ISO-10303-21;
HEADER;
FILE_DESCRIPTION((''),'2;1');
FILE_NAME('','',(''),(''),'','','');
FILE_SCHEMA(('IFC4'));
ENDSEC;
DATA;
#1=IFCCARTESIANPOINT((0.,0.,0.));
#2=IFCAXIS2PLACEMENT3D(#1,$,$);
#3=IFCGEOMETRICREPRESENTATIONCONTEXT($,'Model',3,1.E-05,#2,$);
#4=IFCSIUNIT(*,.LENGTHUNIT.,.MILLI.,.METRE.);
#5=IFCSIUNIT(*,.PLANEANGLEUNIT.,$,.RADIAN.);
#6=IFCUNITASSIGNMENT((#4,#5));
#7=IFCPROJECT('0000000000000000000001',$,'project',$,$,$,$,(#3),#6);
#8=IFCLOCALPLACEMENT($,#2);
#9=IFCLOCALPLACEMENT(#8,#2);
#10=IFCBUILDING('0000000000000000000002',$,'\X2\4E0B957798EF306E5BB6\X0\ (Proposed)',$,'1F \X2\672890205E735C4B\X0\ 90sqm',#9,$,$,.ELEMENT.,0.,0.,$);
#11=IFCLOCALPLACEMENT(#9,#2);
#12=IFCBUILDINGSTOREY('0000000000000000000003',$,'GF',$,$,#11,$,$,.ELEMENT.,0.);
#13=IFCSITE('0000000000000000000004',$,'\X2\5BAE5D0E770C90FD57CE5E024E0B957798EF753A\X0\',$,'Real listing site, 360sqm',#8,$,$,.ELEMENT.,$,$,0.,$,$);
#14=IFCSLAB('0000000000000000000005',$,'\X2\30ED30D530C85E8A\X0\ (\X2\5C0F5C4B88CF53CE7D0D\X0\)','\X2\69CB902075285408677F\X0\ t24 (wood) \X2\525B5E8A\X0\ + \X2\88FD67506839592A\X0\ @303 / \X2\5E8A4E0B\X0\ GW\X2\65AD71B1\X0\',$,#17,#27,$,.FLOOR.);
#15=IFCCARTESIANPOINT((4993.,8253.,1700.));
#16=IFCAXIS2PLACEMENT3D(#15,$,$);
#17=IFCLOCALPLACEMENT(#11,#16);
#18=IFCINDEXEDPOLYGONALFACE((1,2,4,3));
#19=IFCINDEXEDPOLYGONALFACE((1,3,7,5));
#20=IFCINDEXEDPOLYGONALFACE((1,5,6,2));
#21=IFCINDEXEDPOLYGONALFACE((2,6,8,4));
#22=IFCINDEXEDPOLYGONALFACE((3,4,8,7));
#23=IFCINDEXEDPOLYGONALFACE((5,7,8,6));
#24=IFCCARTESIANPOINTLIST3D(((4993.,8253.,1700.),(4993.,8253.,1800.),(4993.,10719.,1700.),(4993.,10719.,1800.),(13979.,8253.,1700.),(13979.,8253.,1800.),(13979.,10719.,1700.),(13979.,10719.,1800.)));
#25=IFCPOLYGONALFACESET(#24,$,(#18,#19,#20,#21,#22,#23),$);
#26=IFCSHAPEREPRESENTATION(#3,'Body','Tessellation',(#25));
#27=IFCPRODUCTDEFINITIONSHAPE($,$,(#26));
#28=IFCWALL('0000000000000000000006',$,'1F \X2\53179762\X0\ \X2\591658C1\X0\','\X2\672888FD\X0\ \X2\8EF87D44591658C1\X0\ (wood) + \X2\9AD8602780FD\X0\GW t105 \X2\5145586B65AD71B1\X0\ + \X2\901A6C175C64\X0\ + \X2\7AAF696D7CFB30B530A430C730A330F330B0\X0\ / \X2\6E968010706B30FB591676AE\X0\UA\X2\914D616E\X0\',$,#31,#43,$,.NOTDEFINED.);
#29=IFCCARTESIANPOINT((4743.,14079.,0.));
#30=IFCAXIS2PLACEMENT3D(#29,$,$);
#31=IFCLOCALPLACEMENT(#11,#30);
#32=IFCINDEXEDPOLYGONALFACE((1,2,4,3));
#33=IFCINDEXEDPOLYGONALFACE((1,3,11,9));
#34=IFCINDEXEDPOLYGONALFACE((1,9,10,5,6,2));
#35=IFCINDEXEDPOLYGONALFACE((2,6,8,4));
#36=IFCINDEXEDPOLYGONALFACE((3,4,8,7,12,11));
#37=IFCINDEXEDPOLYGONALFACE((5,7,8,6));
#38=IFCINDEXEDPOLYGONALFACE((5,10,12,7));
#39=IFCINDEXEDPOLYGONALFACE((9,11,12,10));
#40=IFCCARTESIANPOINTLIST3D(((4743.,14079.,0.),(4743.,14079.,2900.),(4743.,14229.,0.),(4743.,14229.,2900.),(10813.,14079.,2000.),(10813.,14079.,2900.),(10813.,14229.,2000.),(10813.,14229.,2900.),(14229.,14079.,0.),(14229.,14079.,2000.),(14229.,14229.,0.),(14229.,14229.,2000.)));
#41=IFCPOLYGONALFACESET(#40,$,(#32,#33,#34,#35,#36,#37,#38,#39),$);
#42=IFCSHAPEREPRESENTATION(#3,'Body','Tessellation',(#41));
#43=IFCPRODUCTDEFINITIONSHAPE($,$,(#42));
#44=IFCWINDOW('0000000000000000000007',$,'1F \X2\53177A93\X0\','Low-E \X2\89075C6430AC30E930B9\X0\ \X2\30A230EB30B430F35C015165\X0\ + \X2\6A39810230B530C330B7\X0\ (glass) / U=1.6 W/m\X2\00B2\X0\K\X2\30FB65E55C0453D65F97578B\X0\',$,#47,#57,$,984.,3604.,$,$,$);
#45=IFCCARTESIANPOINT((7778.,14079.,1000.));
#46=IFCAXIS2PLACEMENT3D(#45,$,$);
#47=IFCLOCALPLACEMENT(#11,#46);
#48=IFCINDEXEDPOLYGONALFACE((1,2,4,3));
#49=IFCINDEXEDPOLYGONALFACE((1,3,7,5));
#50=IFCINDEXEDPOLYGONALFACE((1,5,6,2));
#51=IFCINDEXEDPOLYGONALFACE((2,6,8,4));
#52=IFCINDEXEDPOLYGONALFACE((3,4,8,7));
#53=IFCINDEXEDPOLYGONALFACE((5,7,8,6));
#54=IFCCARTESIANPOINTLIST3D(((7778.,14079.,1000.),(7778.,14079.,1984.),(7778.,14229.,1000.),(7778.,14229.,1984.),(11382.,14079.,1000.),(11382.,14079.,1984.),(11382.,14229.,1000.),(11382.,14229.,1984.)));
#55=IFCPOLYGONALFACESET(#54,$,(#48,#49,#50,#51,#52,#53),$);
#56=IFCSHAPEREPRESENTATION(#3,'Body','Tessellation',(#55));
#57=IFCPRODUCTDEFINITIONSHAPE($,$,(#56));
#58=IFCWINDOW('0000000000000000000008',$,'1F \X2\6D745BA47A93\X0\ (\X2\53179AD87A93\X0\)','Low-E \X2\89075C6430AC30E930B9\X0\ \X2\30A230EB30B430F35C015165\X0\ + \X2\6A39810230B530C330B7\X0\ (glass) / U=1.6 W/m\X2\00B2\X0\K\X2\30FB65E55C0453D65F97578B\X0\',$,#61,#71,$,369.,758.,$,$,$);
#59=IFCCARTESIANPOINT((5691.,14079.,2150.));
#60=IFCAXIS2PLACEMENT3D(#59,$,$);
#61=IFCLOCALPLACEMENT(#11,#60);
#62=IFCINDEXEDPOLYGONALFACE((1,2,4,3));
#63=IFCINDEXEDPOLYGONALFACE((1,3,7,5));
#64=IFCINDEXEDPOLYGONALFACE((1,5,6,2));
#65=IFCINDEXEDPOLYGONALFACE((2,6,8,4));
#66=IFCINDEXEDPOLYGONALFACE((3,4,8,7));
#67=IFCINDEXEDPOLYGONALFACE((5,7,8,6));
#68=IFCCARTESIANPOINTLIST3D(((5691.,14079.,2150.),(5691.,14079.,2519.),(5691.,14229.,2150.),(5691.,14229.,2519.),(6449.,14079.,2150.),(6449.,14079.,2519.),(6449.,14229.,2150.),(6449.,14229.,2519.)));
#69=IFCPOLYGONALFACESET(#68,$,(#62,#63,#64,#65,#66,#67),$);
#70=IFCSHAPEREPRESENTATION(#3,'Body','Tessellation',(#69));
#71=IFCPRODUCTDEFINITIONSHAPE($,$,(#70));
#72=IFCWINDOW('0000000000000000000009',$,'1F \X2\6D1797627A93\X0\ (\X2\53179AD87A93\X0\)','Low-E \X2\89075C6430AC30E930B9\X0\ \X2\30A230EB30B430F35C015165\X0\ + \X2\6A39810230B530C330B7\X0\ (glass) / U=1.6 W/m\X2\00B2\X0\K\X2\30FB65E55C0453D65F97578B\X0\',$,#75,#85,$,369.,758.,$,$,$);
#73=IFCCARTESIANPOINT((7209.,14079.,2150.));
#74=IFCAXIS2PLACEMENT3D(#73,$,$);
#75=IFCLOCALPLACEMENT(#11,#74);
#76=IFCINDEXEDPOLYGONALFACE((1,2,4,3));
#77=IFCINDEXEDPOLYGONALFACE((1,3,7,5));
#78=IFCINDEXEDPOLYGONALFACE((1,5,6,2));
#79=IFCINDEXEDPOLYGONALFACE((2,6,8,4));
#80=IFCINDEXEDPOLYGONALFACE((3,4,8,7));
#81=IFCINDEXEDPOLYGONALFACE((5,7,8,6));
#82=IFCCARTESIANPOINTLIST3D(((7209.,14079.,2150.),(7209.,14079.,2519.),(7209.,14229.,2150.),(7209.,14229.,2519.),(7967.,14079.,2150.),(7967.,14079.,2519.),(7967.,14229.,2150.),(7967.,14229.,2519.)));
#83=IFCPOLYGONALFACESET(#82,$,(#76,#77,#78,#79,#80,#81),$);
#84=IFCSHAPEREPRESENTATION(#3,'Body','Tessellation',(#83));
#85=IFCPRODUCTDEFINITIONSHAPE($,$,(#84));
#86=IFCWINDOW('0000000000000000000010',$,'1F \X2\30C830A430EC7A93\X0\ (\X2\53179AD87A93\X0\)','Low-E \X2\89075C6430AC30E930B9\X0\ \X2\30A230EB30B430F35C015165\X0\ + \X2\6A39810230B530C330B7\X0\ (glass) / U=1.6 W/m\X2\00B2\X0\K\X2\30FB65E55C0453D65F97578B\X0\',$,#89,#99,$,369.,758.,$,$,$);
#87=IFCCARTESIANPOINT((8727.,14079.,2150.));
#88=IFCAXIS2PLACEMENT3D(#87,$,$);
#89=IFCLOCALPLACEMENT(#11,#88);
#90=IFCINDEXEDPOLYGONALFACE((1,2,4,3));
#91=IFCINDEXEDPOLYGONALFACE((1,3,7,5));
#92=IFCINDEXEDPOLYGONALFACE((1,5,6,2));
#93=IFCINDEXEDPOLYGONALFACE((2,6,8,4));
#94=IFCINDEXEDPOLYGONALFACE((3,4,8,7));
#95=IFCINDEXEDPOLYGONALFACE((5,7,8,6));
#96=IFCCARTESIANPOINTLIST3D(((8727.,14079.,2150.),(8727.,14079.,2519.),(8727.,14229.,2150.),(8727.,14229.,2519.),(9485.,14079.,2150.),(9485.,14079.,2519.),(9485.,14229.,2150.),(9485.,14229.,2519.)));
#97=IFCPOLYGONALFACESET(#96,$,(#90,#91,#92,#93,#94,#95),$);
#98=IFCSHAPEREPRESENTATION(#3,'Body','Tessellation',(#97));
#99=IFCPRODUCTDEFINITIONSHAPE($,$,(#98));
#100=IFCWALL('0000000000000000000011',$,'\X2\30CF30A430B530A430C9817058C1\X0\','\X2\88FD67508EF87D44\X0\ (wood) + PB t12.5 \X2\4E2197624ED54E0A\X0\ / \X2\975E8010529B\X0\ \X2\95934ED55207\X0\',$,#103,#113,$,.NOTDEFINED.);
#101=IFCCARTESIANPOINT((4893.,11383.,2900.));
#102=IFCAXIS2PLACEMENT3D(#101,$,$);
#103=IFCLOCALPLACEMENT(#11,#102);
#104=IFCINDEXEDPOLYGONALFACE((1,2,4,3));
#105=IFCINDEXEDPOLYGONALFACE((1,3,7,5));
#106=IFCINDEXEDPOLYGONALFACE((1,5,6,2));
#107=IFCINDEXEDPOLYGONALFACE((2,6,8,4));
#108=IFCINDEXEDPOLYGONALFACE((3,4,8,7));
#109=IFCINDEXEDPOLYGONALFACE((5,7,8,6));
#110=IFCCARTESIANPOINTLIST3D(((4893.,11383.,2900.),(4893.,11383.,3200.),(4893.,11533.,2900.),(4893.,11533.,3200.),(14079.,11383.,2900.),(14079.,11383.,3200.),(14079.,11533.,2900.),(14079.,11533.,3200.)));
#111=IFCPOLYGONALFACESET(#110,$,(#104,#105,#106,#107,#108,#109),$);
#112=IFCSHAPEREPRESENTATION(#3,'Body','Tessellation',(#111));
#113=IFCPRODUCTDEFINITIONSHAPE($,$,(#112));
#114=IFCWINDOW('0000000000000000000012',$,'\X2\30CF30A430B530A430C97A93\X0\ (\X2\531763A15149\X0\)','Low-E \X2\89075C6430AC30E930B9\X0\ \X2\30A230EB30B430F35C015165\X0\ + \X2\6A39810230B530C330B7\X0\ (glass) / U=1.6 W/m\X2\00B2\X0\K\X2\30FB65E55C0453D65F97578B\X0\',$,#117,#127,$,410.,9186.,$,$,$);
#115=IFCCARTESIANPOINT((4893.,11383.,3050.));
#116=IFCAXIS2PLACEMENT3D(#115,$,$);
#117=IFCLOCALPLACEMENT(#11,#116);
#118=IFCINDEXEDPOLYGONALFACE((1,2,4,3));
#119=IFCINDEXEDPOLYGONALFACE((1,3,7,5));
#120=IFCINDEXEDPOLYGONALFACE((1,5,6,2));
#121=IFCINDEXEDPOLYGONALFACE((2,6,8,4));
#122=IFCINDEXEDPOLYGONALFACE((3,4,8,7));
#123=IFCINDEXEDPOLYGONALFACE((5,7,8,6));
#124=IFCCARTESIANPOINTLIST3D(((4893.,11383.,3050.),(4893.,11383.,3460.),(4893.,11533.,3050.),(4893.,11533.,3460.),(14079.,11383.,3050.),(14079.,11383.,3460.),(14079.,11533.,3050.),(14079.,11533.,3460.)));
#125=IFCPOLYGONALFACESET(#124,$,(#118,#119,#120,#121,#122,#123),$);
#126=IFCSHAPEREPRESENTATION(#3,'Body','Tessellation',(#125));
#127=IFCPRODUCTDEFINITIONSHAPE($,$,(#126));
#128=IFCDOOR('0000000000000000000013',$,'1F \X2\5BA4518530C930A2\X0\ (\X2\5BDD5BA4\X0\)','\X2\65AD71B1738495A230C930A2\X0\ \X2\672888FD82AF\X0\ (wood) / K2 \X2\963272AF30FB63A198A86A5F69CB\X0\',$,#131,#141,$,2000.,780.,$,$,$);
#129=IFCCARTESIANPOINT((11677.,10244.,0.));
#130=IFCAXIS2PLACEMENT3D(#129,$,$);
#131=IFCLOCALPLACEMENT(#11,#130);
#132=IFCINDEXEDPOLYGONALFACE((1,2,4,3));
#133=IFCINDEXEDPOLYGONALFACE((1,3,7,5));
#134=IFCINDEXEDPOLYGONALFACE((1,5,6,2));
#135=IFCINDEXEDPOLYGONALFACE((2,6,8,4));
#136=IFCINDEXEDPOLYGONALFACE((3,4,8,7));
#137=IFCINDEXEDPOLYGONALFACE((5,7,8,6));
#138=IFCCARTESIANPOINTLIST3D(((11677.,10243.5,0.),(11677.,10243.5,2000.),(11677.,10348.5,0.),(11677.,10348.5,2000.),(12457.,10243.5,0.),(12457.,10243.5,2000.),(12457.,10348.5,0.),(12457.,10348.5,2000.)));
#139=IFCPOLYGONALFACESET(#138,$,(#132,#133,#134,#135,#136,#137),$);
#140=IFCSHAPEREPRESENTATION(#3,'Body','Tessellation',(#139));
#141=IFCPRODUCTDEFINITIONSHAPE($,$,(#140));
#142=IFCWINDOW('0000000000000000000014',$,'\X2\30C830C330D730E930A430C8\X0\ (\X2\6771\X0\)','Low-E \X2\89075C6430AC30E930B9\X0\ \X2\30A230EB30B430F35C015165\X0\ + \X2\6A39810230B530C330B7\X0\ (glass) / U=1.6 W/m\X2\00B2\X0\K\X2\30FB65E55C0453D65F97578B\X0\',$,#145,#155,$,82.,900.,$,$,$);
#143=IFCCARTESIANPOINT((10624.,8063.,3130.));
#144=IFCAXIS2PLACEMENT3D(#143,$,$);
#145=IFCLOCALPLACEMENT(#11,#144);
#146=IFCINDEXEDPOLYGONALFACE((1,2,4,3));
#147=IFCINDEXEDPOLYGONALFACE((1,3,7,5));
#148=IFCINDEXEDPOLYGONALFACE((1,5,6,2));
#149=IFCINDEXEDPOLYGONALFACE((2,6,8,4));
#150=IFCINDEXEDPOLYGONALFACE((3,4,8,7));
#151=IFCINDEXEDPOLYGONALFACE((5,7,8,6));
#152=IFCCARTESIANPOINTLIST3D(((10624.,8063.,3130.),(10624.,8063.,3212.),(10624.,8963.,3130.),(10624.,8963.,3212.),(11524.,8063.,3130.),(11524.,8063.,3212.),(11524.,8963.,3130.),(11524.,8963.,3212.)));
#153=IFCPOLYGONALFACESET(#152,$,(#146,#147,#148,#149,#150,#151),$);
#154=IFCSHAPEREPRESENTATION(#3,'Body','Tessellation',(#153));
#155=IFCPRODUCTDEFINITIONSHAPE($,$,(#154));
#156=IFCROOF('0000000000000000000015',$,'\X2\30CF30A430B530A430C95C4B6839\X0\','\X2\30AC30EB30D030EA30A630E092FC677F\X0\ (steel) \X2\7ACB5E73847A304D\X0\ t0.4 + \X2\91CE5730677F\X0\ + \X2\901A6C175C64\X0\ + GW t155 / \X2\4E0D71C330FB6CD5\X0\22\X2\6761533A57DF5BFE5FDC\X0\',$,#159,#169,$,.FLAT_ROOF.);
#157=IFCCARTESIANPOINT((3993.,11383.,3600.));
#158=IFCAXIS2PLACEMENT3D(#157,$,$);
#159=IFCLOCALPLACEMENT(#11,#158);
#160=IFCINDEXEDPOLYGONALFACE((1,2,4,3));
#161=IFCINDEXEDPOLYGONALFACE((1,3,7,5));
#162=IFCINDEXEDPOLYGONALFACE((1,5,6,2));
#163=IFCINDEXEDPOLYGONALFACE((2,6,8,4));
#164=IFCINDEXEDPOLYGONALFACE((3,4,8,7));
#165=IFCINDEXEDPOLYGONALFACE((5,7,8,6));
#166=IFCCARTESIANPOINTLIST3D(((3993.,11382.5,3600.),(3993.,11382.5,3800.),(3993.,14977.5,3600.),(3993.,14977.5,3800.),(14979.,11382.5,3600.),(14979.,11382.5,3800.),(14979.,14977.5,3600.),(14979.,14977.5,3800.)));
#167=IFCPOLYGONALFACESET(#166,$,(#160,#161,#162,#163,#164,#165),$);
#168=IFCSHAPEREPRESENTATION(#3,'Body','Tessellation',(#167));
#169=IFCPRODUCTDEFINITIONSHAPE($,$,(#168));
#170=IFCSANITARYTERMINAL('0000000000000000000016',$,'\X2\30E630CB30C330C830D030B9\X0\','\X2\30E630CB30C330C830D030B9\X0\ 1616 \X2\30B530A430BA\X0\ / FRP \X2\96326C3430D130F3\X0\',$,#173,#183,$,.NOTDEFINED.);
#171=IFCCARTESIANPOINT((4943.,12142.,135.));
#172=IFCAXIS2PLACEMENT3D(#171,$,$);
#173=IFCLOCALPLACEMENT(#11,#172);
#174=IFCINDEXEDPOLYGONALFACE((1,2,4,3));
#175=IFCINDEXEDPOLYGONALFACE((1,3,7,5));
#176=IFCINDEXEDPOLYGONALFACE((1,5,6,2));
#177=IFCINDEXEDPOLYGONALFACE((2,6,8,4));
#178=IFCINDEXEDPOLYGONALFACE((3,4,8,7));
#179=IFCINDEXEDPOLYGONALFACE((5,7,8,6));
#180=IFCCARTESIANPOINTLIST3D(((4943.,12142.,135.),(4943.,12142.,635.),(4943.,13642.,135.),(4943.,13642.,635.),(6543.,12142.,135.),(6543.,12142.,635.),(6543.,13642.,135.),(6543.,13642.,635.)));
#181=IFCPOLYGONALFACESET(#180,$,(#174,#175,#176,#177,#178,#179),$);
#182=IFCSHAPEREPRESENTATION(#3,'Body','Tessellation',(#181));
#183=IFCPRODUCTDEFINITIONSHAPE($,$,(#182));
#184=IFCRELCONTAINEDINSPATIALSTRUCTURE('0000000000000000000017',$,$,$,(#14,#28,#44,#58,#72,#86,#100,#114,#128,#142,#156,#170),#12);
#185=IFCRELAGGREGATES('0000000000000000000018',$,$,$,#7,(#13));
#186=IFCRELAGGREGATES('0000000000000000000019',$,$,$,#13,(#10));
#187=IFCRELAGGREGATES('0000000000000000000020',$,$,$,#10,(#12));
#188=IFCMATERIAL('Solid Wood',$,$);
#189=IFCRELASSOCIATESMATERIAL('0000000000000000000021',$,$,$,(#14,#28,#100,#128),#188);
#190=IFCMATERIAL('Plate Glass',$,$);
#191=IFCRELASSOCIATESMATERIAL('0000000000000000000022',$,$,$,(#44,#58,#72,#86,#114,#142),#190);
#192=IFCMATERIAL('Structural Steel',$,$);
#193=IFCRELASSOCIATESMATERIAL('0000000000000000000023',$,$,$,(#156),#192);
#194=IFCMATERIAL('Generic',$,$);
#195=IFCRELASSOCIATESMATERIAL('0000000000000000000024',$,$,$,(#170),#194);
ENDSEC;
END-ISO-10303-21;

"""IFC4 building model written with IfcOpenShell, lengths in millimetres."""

from ifc_helpers import new_model, si_unit, frame, frame_2d, origin, place, context, project, spatial, rectangle, extrude, material, element, fill, save


model = new_model("IFC4")

# Units and contexts
model_context = context("Model", 3, precision=1e-05, world=origin())
ifc_project = project(units=[si_unit("LENGTHUNIT", "METRE", prefix="MILLI"), si_unit("PLANEANGLEUNIT", "RADIAN")], contexts=[model_context])

# Site, building, storey
site_placement = place(None, origin())
site = spatial("IfcSite", under=ifc_project, at=site_placement, Name="宮崎県都城市下長飯町", ObjectType="Real listing site, 360sqm", CompositionType="ELEMENT", RefElevation=0.0)
building_placement = place(site_placement, origin())
building = spatial("IfcBuilding", under=site, at=building_placement, Name="下長飯の家 (Proposed)", ObjectType="1F 木造平屋 90sqm", CompositionType="ELEMENT", ElevationOfRefHeight=0.0, ElevationOfTerrain=0.0)
storey_placement = place(building_placement, origin())
storey = spatial("IfcBuildingStorey", under=building, at=storey_placement, Name="GF", CompositionType="ELEMENT", Elevation=0.0)

# Slab
ifc_material_1 = material(Name="Solid Wood")
slab_placement = place(storey_placement, frame((4993.0, 8253.0, 1700.0)))
element("IfcSlab", 1, at=slab_placement, inside=storey, material=ifc_material_1, Name="ロフト床 (小屋裏収納)", Description="構造用合板 t24 (wood) 剛床 + 製材根太 @303 / 床下 GW断熱", PredefinedType="FLOOR", context=model_context, shape_type="SweptSolid", body=[
    extrude(rectangle(XDim=8986.0, YDim=2466.0, at=frame_2d((4493.0, 1233.0))), frame((4993.0, 8253.0, 1700.0)), (0.0, 0.0, 1.0), 100.0),
])

# Wall, openings, windows
wall_1_placement = place(storey_placement, frame((4743.0, 14079.0, 0.0)))
wall_1 = element("IfcWall", 2, at=wall_1_placement, inside=storey, material=ifc_material_1, Name="1F 北面 外壁", Description="木製 軸組外壁 (wood) + 高性能GW t105 充填断熱 + 通気層 + 窯業系サイディング / 準耐火・外皮UA配慮", PredefinedType="NOTDEFINED", context=model_context, shape_type="SweptSolid", body=[
    extrude(rectangle(XDim=9486.0, YDim=150.0, at=frame_2d((4743.0, 75.0))), frame((4743.0, 14079.0, 0.0)), (0.0, 0.0, 1.0), 2900.0),
])
opening_1_placement = place(storey_placement, frame((7778.0, 14079.0, 1000.0)))
opening_1 = element("IfcOpeningElement", 3, at=opening_1_placement, cuts=wall_1, PredefinedType="NOTDEFINED", context=model_context, shape_type="SweptSolid", body=[
    extrude(rectangle(XDim=3604.0, YDim=150.0, at=frame_2d((1802.0, 75.0))), frame((7778.0, 14079.0, 1000.0)), (0.0, 0.0, 1.0), 984.0),
])
opening_2_placement = place(storey_placement, frame((5691.0, 14079.0, 2150.0)))
opening_2 = element("IfcOpeningElement", 4, at=opening_2_placement, cuts=wall_1, PredefinedType="NOTDEFINED", context=model_context, shape_type="SweptSolid", body=[
    extrude(rectangle(XDim=758.0, YDim=150.0, at=frame_2d((379.0, 75.0))), frame((5691.0, 14079.0, 2150.0)), (0.0, 0.0, 1.0), 369.0),
])
opening_3_placement = place(storey_placement, frame((7209.0, 14079.0, 2150.0)))
opening_3 = element("IfcOpeningElement", 5, at=opening_3_placement, cuts=wall_1, PredefinedType="NOTDEFINED", context=model_context, shape_type="SweptSolid", body=[
    extrude(rectangle(XDim=758.0, YDim=150.0, at=frame_2d((379.0, 75.0))), frame((7209.0, 14079.0, 2150.0)), (0.0, 0.0, 1.0), 369.0),
])
opening_4_placement = place(storey_placement, frame((8727.0, 14079.0, 2150.0)))
opening_4 = element("IfcOpeningElement", 6, at=opening_4_placement, cuts=wall_1, PredefinedType="NOTDEFINED", context=model_context, shape_type="SweptSolid", body=[
    extrude(rectangle(XDim=758.0, YDim=150.0, at=frame_2d((379.0, 75.0))), frame((8727.0, 14079.0, 2150.0)), (0.0, 0.0, 1.0), 369.0),
])
ifc_material_2 = material(Name="Plate Glass")
window_1_placement = place(storey_placement, frame((7778.0, 14079.0, 1000.0)))
window_1 = element("IfcWindow", 7, at=window_1_placement, inside=storey, material=ifc_material_2, Name="1F 北窓", Description="Low-E 複層ガラス アルゴン封入 + 樹脂サッシ (glass) / U=1.6 W/m²K・日射取得型", OverallHeight=984.0, OverallWidth=3604.0, context=model_context, shape_type="SweptSolid", body=[
    extrude(rectangle(XDim=3604.0, YDim=150.0, at=frame_2d((1802.0, 75.0))), frame((7778.0, 14079.0, 1000.0)), (0.0, 0.0, 1.0), 984.0),
])
fill(opening_1, window_1)
window_2_placement = place(storey_placement, frame((5691.0, 14079.0, 2150.0)))
window_2 = element("IfcWindow", 8, at=window_2_placement, inside=storey, material=ifc_material_2, Name="1F 浴室窓 (北高窓)", Description="Low-E 複層ガラス アルゴン封入 + 樹脂サッシ (glass) / U=1.6 W/m²K・日射取得型", OverallHeight=369.0, OverallWidth=758.0, context=model_context, shape_type="SweptSolid", body=[
    extrude(rectangle(XDim=758.0, YDim=150.0, at=frame_2d((379.0, 75.0))), frame((5691.0, 14079.0, 2150.0)), (0.0, 0.0, 1.0), 369.0),
])
fill(opening_2, window_2)
window_3_placement = place(storey_placement, frame((7209.0, 14079.0, 2150.0)))
window_3 = element("IfcWindow", 9, at=window_3_placement, inside=storey, material=ifc_material_2, Name="1F 洗面窓 (北高窓)", Description="Low-E 複層ガラス アルゴン封入 + 樹脂サッシ (glass) / U=1.6 W/m²K・日射取得型", OverallHeight=369.0, OverallWidth=758.0, context=model_context, shape_type="SweptSolid", body=[
    extrude(rectangle(XDim=758.0, YDim=150.0, at=frame_2d((379.0, 75.0))), frame((7209.0, 14079.0, 2150.0)), (0.0, 0.0, 1.0), 369.0),
])
fill(opening_3, window_3)
window_4_placement = place(storey_placement, frame((8727.0, 14079.0, 2150.0)))
window_4 = element("IfcWindow", 10, at=window_4_placement, inside=storey, material=ifc_material_2, Name="1F トイレ窓 (北高窓)", Description="Low-E 複層ガラス アルゴン封入 + 樹脂サッシ (glass) / U=1.6 W/m²K・日射取得型", OverallHeight=369.0, OverallWidth=758.0, context=model_context, shape_type="SweptSolid", body=[
    extrude(rectangle(XDim=758.0, YDim=150.0, at=frame_2d((379.0, 75.0))), frame((8727.0, 14079.0, 2150.0)), (0.0, 0.0, 1.0), 369.0),
])
fill(opening_4, window_4)

# Wall, opening, window
wall_2_placement = place(storey_placement, frame((4893.0, 11383.0, 2900.0)))
wall_2 = element("IfcWall", 11, at=wall_2_placement, inside=storey, material=ifc_material_1, Name="ハイサイド腰壁", Description="製材軸組 (wood) + PB t12.5 両面仕上 / 非耐力 間仕切", PredefinedType="NOTDEFINED", context=model_context, shape_type="SweptSolid", body=[
    extrude(rectangle(XDim=9186.0, YDim=150.0, at=frame_2d((4593.0, 75.0))), frame((4893.0, 11383.0, 2900.0)), (0.0, 0.0, 1.0), 700.0),
])
opening_5_placement = place(storey_placement, frame((4893.0, 11383.0, 3050.0)))
opening_5 = element("IfcOpeningElement", 12, at=opening_5_placement, cuts=wall_2, PredefinedType="NOTDEFINED", context=model_context, shape_type="SweptSolid", body=[
    extrude(rectangle(XDim=9186.0, YDim=150.0, at=frame_2d((4593.0, 75.0))), frame((4893.0, 11383.0, 3050.0)), (0.0, 0.0, 1.0), 410.0),
])
window_5_placement = place(storey_placement, frame((4893.0, 11383.0, 3050.0)))
window_5 = element("IfcWindow", 13, at=window_5_placement, inside=storey, material=ifc_material_2, Name="ハイサイド窓 (北採光)", Description="Low-E 複層ガラス アルゴン封入 + 樹脂サッシ (glass) / U=1.6 W/m²K・日射取得型", OverallHeight=410.0, OverallWidth=9186.0, context=model_context, shape_type="SweptSolid", body=[
    extrude(rectangle(XDim=9186.0, YDim=150.0, at=frame_2d((4593.0, 75.0))), frame((4893.0, 11383.0, 3050.0)), (0.0, 0.0, 1.0), 410.0),
])
fill(opening_5, window_5)

# Door
door_1_placement = place(storey_placement, frame((11677.0, 10244.0, 0.0)))
element("IfcDoor", 14, at=door_1_placement, inside=storey, material=ifc_material_1, Name="1F 室内ドア (寝室)", Description="断熱玄関ドア 木製芯 (wood) / K2 防犯・採風機構", OverallHeight=2000.0, OverallWidth=780.0, context=model_context, shape_type="SweptSolid", body=[
    extrude(rectangle(XDim=780.0, YDim=105.0, at=frame_2d((390.0, 52.0))), frame((11677.0, 10244.0, 0.0)), (0.0, 0.0, 1.0), 2000.0),
])

# Window
window_6_placement = place(storey_placement, frame((10624.0, 8063.0, 3130.0)))
element("IfcWindow", 15, at=window_6_placement, inside=storey, material=ifc_material_2, Name="トップライト (東)", Description="Low-E 複層ガラス アルゴン封入 + 樹脂サッシ (glass) / U=1.6 W/m²K・日射取得型", OverallHeight=82.0, OverallWidth=900.0, context=model_context, shape_type="SweptSolid", body=[
    extrude(rectangle(XDim=900.0, YDim=900.0, at=frame_2d((450.0, 450.0))), frame((10624.0, 8063.0, 3130.0)), (0.0, 0.0, 1.0), 82.0),
])

# Roof
ifc_material_3 = material(Name="Structural Steel")
roof_placement = place(storey_placement, frame((3993.0, 11383.0, 3600.0)))
element("IfcRoof", 16, at=roof_placement, inside=storey, material=ifc_material_3, Name="ハイサイド屋根", Description="ガルバリウム鋼板 (steel) 立平葺き t0.4 + 野地板 + 通気層 + GW t155 / 不燃・法22条区域対応", PredefinedType="FLAT_ROOF", context=model_context, shape_type="SweptSolid", body=[
    extrude(rectangle(XDim=10986.0, YDim=3595.0, at=frame_2d((5493.0, 1797.0))), frame((3993.0, 11383.0, 3600.0)), (0.0, 0.0, 1.0), 200.0),
])

# Sanitary terminal
ifc_material_4 = material(Name="Generic")
sanitary_terminal_1_placement = place(storey_placement, frame((4943.0, 12142.0, 135.0)))
element("IfcSanitaryTerminal", 17, at=sanitary_terminal_1_placement, inside=storey, material=ifc_material_4, Name="ユニットバス", Description="ユニットバス 1616 サイズ / FRP 防水パン", PredefinedType="NOTDEFINED", context=model_context, shape_type="SweptSolid", body=[
    extrude(rectangle(XDim=1600.0, YDim=1500.0, at=frame_2d((800.0, 750.0))), frame((4943.0, 12142.0, 135.0)), (0.0, 0.0, 1.0), 500.0),
])

save(model, "model.ifc")
